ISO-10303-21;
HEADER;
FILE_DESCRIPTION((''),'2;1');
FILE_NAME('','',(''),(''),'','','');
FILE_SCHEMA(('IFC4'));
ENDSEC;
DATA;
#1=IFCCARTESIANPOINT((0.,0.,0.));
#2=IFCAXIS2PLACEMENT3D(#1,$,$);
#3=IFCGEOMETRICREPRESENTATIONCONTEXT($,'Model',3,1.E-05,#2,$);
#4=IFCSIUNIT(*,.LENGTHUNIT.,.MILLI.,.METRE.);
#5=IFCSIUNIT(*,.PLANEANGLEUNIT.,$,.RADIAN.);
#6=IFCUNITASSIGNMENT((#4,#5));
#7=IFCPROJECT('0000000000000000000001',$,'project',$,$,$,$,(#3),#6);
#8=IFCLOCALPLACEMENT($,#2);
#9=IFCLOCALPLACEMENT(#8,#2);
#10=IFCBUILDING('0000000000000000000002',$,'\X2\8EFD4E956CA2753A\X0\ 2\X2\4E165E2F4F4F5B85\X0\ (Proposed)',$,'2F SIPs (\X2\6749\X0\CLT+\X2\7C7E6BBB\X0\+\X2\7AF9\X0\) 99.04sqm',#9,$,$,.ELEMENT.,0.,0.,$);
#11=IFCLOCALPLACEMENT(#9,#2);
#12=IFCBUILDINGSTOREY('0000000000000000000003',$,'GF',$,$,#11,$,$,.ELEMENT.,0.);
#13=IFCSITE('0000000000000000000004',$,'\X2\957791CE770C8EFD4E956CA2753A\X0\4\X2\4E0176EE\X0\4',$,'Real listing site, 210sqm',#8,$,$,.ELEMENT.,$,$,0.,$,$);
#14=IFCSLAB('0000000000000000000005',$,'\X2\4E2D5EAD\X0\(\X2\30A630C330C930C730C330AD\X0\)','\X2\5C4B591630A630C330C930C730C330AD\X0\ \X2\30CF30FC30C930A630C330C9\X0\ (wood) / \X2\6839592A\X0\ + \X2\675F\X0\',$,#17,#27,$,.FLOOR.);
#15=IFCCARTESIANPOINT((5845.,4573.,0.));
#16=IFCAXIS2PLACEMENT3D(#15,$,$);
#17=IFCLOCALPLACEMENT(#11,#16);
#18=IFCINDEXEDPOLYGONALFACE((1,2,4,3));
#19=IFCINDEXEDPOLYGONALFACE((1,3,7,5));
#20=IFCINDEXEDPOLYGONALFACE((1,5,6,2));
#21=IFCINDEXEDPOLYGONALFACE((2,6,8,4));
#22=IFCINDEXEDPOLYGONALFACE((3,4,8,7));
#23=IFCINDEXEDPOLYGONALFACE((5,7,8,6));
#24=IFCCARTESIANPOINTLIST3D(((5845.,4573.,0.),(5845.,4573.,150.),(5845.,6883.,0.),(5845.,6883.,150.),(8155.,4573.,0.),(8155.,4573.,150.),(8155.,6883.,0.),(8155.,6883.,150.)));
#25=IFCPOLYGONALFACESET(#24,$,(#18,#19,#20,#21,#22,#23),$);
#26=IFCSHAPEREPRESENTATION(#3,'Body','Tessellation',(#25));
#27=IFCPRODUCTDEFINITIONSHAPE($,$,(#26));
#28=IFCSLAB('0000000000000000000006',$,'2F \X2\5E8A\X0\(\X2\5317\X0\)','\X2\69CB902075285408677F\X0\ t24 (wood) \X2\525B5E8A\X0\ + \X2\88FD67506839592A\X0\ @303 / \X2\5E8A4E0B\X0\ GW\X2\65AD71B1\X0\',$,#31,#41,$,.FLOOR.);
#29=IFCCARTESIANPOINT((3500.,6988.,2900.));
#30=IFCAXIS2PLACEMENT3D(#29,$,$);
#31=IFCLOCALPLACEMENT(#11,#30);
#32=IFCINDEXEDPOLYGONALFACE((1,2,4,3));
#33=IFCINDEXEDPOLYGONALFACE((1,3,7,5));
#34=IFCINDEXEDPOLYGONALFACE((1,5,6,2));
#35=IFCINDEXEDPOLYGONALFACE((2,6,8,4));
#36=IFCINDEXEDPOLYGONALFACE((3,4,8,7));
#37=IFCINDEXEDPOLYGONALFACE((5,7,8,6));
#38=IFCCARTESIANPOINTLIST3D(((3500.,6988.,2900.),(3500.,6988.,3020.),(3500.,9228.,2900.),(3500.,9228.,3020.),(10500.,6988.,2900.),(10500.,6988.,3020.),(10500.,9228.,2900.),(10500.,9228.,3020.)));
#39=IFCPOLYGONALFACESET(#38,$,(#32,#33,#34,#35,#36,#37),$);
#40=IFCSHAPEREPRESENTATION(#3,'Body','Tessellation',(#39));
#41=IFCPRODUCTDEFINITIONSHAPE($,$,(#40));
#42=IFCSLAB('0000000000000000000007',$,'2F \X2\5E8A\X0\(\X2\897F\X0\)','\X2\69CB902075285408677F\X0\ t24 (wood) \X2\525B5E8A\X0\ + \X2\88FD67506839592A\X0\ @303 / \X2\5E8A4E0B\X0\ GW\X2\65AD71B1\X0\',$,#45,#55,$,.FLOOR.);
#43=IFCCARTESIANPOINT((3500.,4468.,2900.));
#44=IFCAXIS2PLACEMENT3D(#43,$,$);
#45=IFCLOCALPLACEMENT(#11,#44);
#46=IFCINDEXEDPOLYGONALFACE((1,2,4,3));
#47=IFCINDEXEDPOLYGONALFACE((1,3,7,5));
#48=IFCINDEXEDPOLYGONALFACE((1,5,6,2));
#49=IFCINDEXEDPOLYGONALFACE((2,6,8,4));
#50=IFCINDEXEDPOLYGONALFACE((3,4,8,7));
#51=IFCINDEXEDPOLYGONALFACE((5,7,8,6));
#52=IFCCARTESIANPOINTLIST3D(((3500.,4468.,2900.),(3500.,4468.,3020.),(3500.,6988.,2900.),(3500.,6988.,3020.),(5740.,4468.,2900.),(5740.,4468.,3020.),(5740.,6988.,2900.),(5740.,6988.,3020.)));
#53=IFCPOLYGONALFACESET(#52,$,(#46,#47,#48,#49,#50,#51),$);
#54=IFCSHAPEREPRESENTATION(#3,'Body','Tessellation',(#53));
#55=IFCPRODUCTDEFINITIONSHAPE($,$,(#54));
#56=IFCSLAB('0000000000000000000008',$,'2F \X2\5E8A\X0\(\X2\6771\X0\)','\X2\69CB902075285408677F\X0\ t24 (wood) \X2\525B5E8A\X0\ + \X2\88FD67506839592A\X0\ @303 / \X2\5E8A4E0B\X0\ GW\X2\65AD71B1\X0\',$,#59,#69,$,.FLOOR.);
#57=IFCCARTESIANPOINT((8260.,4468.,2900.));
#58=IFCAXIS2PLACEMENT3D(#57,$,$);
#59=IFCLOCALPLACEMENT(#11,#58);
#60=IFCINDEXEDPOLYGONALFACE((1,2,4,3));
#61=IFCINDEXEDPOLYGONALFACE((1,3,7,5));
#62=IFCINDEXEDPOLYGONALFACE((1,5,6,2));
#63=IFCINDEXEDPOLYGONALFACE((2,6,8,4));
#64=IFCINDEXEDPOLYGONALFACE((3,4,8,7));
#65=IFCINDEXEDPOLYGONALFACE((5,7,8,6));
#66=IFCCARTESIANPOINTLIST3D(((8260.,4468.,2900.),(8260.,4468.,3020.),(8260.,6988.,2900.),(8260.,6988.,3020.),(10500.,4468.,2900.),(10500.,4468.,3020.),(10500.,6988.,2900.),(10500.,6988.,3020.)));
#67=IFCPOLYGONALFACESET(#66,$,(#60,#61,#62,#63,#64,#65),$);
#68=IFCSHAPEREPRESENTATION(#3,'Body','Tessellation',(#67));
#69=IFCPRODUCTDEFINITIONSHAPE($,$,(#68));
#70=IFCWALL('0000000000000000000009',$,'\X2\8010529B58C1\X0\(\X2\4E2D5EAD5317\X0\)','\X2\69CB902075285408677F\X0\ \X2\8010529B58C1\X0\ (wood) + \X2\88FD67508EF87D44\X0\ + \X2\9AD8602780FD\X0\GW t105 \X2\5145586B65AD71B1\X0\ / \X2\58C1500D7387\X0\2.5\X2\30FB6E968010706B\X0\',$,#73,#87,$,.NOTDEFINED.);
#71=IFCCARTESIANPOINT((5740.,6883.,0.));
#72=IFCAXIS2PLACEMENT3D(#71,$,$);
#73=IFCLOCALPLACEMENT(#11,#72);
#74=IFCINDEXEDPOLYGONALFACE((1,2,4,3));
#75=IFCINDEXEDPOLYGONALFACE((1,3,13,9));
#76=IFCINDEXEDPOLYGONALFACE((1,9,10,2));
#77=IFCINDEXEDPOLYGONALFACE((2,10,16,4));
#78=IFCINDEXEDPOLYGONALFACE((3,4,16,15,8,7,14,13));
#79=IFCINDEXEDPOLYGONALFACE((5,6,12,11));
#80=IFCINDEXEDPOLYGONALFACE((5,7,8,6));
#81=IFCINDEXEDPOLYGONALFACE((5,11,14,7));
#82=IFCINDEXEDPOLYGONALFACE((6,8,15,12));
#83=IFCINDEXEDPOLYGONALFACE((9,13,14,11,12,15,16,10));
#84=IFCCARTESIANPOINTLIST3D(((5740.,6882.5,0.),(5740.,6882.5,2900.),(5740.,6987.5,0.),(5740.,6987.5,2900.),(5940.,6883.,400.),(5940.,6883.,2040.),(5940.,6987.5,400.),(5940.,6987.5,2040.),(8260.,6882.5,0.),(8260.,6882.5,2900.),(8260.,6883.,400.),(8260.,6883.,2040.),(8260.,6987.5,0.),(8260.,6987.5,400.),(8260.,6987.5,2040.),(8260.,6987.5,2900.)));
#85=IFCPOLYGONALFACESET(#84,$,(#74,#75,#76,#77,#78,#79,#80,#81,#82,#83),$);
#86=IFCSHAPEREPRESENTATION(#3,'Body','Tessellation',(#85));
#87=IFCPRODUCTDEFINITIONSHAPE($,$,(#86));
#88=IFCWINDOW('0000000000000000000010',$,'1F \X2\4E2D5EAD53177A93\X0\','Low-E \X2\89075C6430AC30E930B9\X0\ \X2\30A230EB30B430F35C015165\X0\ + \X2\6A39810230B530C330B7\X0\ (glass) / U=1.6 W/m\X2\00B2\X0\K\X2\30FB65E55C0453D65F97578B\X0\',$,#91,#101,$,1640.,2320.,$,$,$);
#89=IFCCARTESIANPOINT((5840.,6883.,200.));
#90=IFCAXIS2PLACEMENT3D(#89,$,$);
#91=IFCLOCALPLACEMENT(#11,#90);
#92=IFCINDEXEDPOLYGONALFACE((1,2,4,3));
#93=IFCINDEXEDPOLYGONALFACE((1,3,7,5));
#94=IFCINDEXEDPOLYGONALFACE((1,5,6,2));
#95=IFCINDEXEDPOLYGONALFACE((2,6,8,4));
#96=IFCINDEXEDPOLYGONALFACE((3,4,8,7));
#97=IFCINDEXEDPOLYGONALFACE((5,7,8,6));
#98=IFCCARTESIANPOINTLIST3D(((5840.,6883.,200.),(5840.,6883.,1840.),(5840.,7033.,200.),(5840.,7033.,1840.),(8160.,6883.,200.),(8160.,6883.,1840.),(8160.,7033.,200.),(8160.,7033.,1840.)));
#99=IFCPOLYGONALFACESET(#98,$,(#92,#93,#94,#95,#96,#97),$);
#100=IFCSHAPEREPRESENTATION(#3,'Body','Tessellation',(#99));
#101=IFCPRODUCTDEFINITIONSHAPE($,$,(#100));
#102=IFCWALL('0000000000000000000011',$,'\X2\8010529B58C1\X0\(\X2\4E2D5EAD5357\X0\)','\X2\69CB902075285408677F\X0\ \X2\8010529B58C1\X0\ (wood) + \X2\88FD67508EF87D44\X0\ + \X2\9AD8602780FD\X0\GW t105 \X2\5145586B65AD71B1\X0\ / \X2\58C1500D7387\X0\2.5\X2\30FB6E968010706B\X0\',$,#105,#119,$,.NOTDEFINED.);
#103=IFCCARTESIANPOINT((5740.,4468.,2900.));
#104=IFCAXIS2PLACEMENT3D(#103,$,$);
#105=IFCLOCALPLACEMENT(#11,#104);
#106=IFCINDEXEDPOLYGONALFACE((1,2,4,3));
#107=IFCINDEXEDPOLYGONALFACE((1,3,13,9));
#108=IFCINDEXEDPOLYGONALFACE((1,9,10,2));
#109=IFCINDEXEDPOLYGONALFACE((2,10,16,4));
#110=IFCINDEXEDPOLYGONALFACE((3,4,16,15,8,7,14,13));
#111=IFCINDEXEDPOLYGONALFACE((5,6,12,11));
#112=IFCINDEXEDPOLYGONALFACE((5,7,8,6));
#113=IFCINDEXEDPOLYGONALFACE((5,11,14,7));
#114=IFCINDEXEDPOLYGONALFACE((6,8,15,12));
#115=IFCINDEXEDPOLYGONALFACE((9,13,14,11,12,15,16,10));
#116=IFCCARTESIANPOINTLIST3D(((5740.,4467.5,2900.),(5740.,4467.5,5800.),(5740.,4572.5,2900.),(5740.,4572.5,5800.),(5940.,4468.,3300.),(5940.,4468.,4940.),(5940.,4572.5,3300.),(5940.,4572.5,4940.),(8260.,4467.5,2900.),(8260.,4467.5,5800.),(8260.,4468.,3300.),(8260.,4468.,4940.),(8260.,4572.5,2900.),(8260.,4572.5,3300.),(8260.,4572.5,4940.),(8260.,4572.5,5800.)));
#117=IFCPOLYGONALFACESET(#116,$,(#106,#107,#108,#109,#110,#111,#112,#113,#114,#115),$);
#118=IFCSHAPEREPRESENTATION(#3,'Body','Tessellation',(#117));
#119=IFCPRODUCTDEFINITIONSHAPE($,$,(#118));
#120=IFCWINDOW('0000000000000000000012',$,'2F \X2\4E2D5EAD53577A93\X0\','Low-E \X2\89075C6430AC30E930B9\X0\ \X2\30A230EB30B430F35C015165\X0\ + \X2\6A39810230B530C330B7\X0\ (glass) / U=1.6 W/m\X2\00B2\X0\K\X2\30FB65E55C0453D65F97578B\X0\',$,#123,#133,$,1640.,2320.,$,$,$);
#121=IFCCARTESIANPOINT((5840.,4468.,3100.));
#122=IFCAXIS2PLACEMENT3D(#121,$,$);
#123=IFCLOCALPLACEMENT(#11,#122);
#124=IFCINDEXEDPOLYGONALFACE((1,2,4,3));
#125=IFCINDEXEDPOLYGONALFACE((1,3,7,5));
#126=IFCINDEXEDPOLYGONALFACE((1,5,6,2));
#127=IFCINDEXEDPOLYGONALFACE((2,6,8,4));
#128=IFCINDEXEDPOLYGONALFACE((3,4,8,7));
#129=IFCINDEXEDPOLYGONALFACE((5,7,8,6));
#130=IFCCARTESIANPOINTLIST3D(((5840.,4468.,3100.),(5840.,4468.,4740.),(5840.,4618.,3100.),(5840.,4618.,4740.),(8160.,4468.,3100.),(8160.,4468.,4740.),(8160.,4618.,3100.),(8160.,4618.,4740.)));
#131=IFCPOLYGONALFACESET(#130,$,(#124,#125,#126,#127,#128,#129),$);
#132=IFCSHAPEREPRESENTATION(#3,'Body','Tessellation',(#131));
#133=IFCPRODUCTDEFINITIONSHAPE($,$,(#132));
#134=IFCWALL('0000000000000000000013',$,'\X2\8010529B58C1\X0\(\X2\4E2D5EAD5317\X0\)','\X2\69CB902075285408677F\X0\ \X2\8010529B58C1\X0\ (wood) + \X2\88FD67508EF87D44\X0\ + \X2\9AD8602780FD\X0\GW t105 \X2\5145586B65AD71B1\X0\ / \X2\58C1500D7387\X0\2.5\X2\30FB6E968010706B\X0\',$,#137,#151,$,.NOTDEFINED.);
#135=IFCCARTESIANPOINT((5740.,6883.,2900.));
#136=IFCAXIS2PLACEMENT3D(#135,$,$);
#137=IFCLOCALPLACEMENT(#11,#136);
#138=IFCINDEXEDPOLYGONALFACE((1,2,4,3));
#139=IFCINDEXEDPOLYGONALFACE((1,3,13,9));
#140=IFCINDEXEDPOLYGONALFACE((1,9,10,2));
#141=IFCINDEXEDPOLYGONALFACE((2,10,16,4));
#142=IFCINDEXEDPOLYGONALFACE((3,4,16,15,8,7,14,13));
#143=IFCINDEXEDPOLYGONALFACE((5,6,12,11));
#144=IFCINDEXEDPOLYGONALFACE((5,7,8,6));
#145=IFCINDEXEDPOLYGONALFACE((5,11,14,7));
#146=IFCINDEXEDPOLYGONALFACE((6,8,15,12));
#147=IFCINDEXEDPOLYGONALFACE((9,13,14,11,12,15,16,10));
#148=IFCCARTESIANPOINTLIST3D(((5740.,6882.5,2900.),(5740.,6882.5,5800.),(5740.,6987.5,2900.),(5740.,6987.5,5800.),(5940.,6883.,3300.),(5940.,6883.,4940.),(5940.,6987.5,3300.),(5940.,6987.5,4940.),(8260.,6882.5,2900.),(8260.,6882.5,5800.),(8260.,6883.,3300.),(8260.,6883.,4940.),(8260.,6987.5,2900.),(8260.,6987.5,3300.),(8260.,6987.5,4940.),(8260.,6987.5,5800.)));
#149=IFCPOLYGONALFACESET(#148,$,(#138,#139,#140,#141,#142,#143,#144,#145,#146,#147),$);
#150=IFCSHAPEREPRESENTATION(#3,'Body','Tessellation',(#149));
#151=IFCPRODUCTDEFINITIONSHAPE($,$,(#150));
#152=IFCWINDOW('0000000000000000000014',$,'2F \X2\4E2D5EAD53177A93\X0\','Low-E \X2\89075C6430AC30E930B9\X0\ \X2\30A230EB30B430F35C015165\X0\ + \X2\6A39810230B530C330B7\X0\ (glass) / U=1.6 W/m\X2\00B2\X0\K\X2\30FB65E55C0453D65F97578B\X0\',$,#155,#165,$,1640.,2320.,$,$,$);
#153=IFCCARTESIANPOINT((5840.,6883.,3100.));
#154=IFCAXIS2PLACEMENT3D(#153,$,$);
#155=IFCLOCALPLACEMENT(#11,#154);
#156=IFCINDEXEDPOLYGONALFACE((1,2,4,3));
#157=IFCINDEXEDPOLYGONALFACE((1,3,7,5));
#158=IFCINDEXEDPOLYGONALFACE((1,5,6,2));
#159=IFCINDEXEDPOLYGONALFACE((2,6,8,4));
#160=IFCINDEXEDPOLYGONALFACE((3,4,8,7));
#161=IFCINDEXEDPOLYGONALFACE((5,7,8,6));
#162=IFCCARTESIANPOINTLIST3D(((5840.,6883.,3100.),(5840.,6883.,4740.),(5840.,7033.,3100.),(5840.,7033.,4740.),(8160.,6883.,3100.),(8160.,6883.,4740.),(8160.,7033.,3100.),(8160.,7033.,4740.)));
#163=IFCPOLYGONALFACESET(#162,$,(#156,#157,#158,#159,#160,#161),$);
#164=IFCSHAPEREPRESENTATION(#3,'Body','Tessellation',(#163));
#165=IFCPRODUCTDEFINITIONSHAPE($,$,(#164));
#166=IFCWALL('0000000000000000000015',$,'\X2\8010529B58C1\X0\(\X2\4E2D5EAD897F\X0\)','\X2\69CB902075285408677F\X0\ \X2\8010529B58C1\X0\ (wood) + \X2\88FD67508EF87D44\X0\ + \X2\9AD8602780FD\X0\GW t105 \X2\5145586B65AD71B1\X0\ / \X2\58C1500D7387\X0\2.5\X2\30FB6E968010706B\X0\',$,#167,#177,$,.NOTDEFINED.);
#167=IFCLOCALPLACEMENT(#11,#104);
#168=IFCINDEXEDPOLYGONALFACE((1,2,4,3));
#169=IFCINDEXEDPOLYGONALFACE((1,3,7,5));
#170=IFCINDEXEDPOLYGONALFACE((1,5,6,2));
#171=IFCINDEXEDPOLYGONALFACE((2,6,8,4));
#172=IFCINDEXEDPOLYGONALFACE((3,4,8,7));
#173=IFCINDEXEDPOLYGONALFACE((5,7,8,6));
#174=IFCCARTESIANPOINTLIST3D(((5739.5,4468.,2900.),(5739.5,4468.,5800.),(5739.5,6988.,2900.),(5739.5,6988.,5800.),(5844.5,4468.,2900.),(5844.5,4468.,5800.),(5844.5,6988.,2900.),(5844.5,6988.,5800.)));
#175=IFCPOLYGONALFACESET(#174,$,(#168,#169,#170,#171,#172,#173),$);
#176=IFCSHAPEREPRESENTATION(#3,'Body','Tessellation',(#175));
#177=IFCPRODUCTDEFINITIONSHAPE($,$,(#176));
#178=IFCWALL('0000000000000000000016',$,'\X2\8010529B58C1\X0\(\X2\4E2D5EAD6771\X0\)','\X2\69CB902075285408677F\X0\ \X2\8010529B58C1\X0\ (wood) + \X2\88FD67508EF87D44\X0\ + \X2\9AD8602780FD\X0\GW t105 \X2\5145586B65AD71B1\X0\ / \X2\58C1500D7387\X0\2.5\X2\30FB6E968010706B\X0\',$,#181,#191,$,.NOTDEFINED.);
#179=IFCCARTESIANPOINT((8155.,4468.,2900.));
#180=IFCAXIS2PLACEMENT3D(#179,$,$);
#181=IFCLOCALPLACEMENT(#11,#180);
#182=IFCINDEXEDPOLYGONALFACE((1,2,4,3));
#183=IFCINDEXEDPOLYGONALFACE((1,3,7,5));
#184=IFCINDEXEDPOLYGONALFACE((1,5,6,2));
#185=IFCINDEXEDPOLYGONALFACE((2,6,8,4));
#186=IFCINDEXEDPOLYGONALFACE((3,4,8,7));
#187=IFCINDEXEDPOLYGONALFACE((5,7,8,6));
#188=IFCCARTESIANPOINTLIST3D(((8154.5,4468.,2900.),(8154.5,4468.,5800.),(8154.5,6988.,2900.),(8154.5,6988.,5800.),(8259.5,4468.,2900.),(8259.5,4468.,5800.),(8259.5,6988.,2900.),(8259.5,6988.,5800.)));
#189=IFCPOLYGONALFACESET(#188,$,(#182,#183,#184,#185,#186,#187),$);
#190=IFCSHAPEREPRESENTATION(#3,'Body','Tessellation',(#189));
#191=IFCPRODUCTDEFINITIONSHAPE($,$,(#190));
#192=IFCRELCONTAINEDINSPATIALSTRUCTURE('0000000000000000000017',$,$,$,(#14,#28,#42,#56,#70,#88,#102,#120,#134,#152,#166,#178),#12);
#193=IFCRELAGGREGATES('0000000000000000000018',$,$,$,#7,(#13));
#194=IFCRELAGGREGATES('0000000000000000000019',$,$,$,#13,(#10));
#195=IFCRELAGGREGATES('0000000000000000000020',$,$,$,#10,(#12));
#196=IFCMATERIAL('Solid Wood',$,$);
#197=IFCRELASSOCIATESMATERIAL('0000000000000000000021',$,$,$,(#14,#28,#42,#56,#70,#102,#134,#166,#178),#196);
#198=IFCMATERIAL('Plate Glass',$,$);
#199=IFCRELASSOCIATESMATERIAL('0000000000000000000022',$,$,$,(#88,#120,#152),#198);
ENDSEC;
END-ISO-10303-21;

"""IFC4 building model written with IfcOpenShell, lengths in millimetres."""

from ifc_helpers import new_model, si_unit, frame, frame_2d, origin, place, context, project, spatial, rectangle, extrude, material, element, fill, save


model = new_model("IFC4")

# Units and contexts
model_context = context("Model", 3, precision=1e-05, world=origin())
ifc_project = project(units=[si_unit("LENGTHUNIT", "METRE", prefix="MILLI"), si_unit("PLANEANGLEUNIT", "RADIAN")], contexts=[model_context])

# Site, building, storey
site_placement = place(None, origin())
site = spatial("IfcSite", under=ifc_project, at=site_placement, Name="長野県軽井沢町4丁目4", ObjectType="Real listing site, 210sqm", CompositionType="ELEMENT", RefElevation=0.0)
building_placement = place(site_placement, origin())
building = spatial("IfcBuilding", under=site, at=building_placement, Name="軽井沢町 2世帯住宅 (Proposed)", ObjectType="2F SIPs (杉CLT+籾殻+竹) 99.04sqm", CompositionType="ELEMENT", ElevationOfRefHeight=0.0, ElevationOfTerrain=0.0)
storey_placement = place(building_placement, origin())
storey = spatial("IfcBuildingStorey", under=building, at=storey_placement, Name="GF", CompositionType="ELEMENT", Elevation=0.0)

# Slabs
ifc_material_1 = material(Name="Solid Wood")
slab_1_placement = place(storey_placement, frame((5845.0, 4573.0, 0.0)))
element("IfcSlab", 1, at=slab_1_placement, inside=storey, material=ifc_material_1, Name="中庭(ウッドデッキ)", Description="屋外ウッドデッキ ハードウッド (wood) / 根太 + 束", PredefinedType="FLOOR", context=model_context, shape_type="SweptSolid", body=[
    extrude(rectangle(XDim=2310.0, YDim=2310.0, at=frame_2d((1155.0, 1155.0))), frame((5845.0, 4573.0, 0.0)), (0.0, 0.0, 1.0), 150.0),
])
slab_2_placement = place(storey_placement, frame((3500.0, 6988.0, 2900.0)))
element("IfcSlab", 2, at=slab_2_placement, inside=storey, material=ifc_material_1, Name="2F 床(北)", Description="構造用合板 t24 (wood) 剛床 + 製材根太 @303 / 床下 GW断熱", PredefinedType="FLOOR", context=model_context, shape_type="SweptSolid", body=[
    extrude(rectangle(XDim=7000.0, YDim=2240.0, at=frame_2d((3500.0, 1120.0))), frame((3500.0, 6988.0, 2900.0)), (0.0, 0.0, 1.0), 120.0),
])
slab_3_placement = place(storey_placement, frame((3500.0, 4468.0, 2900.0)))
element("IfcSlab", 3, at=slab_3_placement, inside=storey, material=ifc_material_1, Name="2F 床(西)", Description="構造用合板 t24 (wood) 剛床 + 製材根太 @303 / 床下 GW断熱", PredefinedType="FLOOR", context=model_context, shape_type="SweptSolid", body=[
    extrude(rectangle(XDim=2240.0, YDim=2520.0, at=frame_2d((1120.0, 1260.0))), frame((3500.0, 4468.0, 2900.0)), (0.0, 0.0, 1.0), 120.0),
])
slab_4_placement = place(storey_placement, frame((8260.0, 4468.0, 2900.0)))
element("IfcSlab", 4, at=slab_4_placement, inside=storey, material=ifc_material_1, Name="2F 床(東)", Description="構造用合板 t24 (wood) 剛床 + 製材根太 @303 / 床下 GW断熱", PredefinedType="FLOOR", context=model_context, shape_type="SweptSolid", body=[
    extrude(rectangle(XDim=2240.0, YDim=2520.0, at=frame_2d((1120.0, 1260.0))), frame((8260.0, 4468.0, 2900.0)), (0.0, 0.0, 1.0), 120.0),
])

# Wall, opening, window
wall_1_placement = place(storey_placement, frame((5740.0, 6883.0, 0.0)))
wall_1 = element("IfcWall", 5, at=wall_1_placement, inside=storey, material=ifc_material_1, Name="耐力壁(中庭北)", Description="構造用合板 耐力壁 (wood) + 製材軸組 + 高性能GW t105 充填断熱 / 壁倍率2.5・準耐火", PredefinedType="NOTDEFINED", context=model_context, shape_type="SweptSolid", body=[
    extrude(rectangle(XDim=2520.0, YDim=105.0, at=frame_2d((1260.0, 52.0))), frame((5740.0, 6883.0, 0.0)), (0.0, 0.0, 1.0), 2900.0),
])
opening_1_placement = place(storey_placement, frame((5840.0, 6883.0, 200.0)))
opening_1 = element("IfcOpeningElement", 6, at=opening_1_placement, cuts=wall_1, PredefinedType="NOTDEFINED", context=model_context, shape_type="SweptSolid", body=[
    extrude(rectangle(XDim=2320.0, YDim=150.0, at=frame_2d((1160.0, 75.0))), frame((5840.0, 6883.0, 200.0)), (0.0, 0.0, 1.0), 1640.0),
])
ifc_material_2 = material(Name="Plate Glass")
window_1_placement = place(storey_placement, frame((5840.0, 6883.0, 200.0)))
window_1 = element("IfcWindow", 7, at=window_1_placement, inside=storey, material=ifc_material_2, Name="1F 中庭北窓", Description="Low-E 複層ガラス アルゴン封入 + 樹脂サッシ (glass) / U=1.6 W/m²K・日射取得型", OverallHeight=1640.0, OverallWidth=2320.0, context=model_context, shape_type="SweptSolid", body=[
    extrude(rectangle(XDim=2320.0, YDim=150.0, at=frame_2d((1160.0, 75.0))), frame((5840.0, 6883.0, 200.0)), (0.0, 0.0, 1.0), 1640.0),
])
fill(opening_1, window_1)

# Walls, openings, windows
wall_2_placement = place(storey_placement, frame((5740.0, 4468.0, 2900.0)))
wall_2 = element("IfcWall", 8, at=wall_2_placement, inside=storey, material=ifc_material_1, Name="耐力壁(中庭南)", Description="構造用合板 耐力壁 (wood) + 製材軸組 + 高性能GW t105 充填断熱 / 壁倍率2.5・準耐火", PredefinedType="NOTDEFINED", context=model_context, shape_type="SweptSolid", body=[
    extrude(rectangle(XDim=2520.0, YDim=105.0, at=frame_2d((1260.0, 52.0))), frame((5740.0, 4468.0, 2900.0)), (0.0, 0.0, 1.0), 2900.0),
])
opening_2_placement = place(storey_placement, frame((5840.0, 4468.0, 3100.0)))
opening_2 = element("IfcOpeningElement", 9, at=opening_2_placement, cuts=wall_2, PredefinedType="NOTDEFINED", context=model_context, shape_type="SweptSolid", body=[
    extrude(rectangle(XDim=2320.0, YDim=150.0, at=frame_2d((1160.0, 75.0))), frame((5840.0, 4468.0, 3100.0)), (0.0, 0.0, 1.0), 1640.0),
])
window_2_placement = place(storey_placement, frame((5840.0, 4468.0, 3100.0)))
window_2 = element("IfcWindow", 10, at=window_2_placement, inside=storey, material=ifc_material_2, Name="2F 中庭南窓", Description="Low-E 複層ガラス アルゴン封入 + 樹脂サッシ (glass) / U=1.6 W/m²K・日射取得型", OverallHeight=1640.0, OverallWidth=2320.0, context=model_context, shape_type="SweptSolid", body=[
    extrude(rectangle(XDim=2320.0, YDim=150.0, at=frame_2d((1160.0, 75.0))), frame((5840.0, 4468.0, 3100.0)), (0.0, 0.0, 1.0), 1640.0),
])
fill(opening_2, window_2)
wall_3_placement = place(storey_placement, frame((5740.0, 6883.0, 2900.0)))
wall_3 = element("IfcWall", 11, at=wall_3_placement, inside=storey, material=ifc_material_1, Name="耐力壁(中庭北)", Description="構造用合板 耐力壁 (wood) + 製材軸組 + 高性能GW t105 充填断熱 / 壁倍率2.5・準耐火", PredefinedType="NOTDEFINED", context=model_context, shape_type="SweptSolid", body=[
    extrude(rectangle(XDim=2520.0, YDim=105.0, at=frame_2d((1260.0, 52.0))), frame((5740.0, 6883.0, 2900.0)), (0.0, 0.0, 1.0), 2900.0),
])
opening_3_placement = place(storey_placement, frame((5840.0, 6883.0, 3100.0)))
opening_3 = element("IfcOpeningElement", 12, at=opening_3_placement, cuts=wall_3, PredefinedType="NOTDEFINED", context=model_context, shape_type="SweptSolid", body=[
    extrude(rectangle(XDim=2320.0, YDim=150.0, at=frame_2d((1160.0, 75.0))), frame((5840.0, 6883.0, 3100.0)), (0.0, 0.0, 1.0), 1640.0),
])
window_3_placement = place(storey_placement, frame((5840.0, 6883.0, 3100.0)))
window_3 = element("IfcWindow", 13, at=window_3_placement, inside=storey, material=ifc_material_2, Name="2F 中庭北窓", Description="Low-E 複層ガラス アルゴン封入 + 樹脂サッシ (glass) / U=1.6 W/m²K・日射取得型", OverallHeight=1640.0, OverallWidth=2320.0, context=model_context, shape_type="SweptSolid", body=[
    extrude(rectangle(XDim=2320.0, YDim=150.0, at=frame_2d((1160.0, 75.0))), frame((5840.0, 6883.0, 3100.0)), (0.0, 0.0, 1.0), 1640.0),
])
fill(opening_3, window_3)

# Walls
wall_4_placement = place(storey_placement, frame((5740.0, 4468.0, 2900.0)))
element("IfcWall", 14, at=wall_4_placement, inside=storey, material=ifc_material_1, Name="耐力壁(中庭西)", Description="構造用合板 耐力壁 (wood) + 製材軸組 + 高性能GW t105 充填断熱 / 壁倍率2.5・準耐火", PredefinedType="NOTDEFINED", context=model_context, shape_type="SweptSolid", body=[
    extrude(rectangle(XDim=105.0, YDim=2520.0, at=frame_2d((52.0, 1260.0))), frame((5740.0, 4468.0, 2900.0)), (0.0, 0.0, 1.0), 2900.0),
])
wall_5_placement = place(storey_placement, frame((8155.0, 4468.0, 2900.0)))
element("IfcWall", 15, at=wall_5_placement, inside=storey, material=ifc_material_1, Name="耐力壁(中庭東)", Description="構造用合板 耐力壁 (wood) + 製材軸組 + 高性能GW t105 充填断熱 / 壁倍率2.5・準耐火", PredefinedType="NOTDEFINED", context=model_context, shape_type="SweptSolid", body=[
    extrude(rectangle(XDim=105.0, YDim=2520.0, at=frame_2d((52.0, 1260.0))), frame((8155.0, 4468.0, 2900.0)), (0.0, 0.0, 1.0), 2900.0),
])

save(model, "model.ifc")
